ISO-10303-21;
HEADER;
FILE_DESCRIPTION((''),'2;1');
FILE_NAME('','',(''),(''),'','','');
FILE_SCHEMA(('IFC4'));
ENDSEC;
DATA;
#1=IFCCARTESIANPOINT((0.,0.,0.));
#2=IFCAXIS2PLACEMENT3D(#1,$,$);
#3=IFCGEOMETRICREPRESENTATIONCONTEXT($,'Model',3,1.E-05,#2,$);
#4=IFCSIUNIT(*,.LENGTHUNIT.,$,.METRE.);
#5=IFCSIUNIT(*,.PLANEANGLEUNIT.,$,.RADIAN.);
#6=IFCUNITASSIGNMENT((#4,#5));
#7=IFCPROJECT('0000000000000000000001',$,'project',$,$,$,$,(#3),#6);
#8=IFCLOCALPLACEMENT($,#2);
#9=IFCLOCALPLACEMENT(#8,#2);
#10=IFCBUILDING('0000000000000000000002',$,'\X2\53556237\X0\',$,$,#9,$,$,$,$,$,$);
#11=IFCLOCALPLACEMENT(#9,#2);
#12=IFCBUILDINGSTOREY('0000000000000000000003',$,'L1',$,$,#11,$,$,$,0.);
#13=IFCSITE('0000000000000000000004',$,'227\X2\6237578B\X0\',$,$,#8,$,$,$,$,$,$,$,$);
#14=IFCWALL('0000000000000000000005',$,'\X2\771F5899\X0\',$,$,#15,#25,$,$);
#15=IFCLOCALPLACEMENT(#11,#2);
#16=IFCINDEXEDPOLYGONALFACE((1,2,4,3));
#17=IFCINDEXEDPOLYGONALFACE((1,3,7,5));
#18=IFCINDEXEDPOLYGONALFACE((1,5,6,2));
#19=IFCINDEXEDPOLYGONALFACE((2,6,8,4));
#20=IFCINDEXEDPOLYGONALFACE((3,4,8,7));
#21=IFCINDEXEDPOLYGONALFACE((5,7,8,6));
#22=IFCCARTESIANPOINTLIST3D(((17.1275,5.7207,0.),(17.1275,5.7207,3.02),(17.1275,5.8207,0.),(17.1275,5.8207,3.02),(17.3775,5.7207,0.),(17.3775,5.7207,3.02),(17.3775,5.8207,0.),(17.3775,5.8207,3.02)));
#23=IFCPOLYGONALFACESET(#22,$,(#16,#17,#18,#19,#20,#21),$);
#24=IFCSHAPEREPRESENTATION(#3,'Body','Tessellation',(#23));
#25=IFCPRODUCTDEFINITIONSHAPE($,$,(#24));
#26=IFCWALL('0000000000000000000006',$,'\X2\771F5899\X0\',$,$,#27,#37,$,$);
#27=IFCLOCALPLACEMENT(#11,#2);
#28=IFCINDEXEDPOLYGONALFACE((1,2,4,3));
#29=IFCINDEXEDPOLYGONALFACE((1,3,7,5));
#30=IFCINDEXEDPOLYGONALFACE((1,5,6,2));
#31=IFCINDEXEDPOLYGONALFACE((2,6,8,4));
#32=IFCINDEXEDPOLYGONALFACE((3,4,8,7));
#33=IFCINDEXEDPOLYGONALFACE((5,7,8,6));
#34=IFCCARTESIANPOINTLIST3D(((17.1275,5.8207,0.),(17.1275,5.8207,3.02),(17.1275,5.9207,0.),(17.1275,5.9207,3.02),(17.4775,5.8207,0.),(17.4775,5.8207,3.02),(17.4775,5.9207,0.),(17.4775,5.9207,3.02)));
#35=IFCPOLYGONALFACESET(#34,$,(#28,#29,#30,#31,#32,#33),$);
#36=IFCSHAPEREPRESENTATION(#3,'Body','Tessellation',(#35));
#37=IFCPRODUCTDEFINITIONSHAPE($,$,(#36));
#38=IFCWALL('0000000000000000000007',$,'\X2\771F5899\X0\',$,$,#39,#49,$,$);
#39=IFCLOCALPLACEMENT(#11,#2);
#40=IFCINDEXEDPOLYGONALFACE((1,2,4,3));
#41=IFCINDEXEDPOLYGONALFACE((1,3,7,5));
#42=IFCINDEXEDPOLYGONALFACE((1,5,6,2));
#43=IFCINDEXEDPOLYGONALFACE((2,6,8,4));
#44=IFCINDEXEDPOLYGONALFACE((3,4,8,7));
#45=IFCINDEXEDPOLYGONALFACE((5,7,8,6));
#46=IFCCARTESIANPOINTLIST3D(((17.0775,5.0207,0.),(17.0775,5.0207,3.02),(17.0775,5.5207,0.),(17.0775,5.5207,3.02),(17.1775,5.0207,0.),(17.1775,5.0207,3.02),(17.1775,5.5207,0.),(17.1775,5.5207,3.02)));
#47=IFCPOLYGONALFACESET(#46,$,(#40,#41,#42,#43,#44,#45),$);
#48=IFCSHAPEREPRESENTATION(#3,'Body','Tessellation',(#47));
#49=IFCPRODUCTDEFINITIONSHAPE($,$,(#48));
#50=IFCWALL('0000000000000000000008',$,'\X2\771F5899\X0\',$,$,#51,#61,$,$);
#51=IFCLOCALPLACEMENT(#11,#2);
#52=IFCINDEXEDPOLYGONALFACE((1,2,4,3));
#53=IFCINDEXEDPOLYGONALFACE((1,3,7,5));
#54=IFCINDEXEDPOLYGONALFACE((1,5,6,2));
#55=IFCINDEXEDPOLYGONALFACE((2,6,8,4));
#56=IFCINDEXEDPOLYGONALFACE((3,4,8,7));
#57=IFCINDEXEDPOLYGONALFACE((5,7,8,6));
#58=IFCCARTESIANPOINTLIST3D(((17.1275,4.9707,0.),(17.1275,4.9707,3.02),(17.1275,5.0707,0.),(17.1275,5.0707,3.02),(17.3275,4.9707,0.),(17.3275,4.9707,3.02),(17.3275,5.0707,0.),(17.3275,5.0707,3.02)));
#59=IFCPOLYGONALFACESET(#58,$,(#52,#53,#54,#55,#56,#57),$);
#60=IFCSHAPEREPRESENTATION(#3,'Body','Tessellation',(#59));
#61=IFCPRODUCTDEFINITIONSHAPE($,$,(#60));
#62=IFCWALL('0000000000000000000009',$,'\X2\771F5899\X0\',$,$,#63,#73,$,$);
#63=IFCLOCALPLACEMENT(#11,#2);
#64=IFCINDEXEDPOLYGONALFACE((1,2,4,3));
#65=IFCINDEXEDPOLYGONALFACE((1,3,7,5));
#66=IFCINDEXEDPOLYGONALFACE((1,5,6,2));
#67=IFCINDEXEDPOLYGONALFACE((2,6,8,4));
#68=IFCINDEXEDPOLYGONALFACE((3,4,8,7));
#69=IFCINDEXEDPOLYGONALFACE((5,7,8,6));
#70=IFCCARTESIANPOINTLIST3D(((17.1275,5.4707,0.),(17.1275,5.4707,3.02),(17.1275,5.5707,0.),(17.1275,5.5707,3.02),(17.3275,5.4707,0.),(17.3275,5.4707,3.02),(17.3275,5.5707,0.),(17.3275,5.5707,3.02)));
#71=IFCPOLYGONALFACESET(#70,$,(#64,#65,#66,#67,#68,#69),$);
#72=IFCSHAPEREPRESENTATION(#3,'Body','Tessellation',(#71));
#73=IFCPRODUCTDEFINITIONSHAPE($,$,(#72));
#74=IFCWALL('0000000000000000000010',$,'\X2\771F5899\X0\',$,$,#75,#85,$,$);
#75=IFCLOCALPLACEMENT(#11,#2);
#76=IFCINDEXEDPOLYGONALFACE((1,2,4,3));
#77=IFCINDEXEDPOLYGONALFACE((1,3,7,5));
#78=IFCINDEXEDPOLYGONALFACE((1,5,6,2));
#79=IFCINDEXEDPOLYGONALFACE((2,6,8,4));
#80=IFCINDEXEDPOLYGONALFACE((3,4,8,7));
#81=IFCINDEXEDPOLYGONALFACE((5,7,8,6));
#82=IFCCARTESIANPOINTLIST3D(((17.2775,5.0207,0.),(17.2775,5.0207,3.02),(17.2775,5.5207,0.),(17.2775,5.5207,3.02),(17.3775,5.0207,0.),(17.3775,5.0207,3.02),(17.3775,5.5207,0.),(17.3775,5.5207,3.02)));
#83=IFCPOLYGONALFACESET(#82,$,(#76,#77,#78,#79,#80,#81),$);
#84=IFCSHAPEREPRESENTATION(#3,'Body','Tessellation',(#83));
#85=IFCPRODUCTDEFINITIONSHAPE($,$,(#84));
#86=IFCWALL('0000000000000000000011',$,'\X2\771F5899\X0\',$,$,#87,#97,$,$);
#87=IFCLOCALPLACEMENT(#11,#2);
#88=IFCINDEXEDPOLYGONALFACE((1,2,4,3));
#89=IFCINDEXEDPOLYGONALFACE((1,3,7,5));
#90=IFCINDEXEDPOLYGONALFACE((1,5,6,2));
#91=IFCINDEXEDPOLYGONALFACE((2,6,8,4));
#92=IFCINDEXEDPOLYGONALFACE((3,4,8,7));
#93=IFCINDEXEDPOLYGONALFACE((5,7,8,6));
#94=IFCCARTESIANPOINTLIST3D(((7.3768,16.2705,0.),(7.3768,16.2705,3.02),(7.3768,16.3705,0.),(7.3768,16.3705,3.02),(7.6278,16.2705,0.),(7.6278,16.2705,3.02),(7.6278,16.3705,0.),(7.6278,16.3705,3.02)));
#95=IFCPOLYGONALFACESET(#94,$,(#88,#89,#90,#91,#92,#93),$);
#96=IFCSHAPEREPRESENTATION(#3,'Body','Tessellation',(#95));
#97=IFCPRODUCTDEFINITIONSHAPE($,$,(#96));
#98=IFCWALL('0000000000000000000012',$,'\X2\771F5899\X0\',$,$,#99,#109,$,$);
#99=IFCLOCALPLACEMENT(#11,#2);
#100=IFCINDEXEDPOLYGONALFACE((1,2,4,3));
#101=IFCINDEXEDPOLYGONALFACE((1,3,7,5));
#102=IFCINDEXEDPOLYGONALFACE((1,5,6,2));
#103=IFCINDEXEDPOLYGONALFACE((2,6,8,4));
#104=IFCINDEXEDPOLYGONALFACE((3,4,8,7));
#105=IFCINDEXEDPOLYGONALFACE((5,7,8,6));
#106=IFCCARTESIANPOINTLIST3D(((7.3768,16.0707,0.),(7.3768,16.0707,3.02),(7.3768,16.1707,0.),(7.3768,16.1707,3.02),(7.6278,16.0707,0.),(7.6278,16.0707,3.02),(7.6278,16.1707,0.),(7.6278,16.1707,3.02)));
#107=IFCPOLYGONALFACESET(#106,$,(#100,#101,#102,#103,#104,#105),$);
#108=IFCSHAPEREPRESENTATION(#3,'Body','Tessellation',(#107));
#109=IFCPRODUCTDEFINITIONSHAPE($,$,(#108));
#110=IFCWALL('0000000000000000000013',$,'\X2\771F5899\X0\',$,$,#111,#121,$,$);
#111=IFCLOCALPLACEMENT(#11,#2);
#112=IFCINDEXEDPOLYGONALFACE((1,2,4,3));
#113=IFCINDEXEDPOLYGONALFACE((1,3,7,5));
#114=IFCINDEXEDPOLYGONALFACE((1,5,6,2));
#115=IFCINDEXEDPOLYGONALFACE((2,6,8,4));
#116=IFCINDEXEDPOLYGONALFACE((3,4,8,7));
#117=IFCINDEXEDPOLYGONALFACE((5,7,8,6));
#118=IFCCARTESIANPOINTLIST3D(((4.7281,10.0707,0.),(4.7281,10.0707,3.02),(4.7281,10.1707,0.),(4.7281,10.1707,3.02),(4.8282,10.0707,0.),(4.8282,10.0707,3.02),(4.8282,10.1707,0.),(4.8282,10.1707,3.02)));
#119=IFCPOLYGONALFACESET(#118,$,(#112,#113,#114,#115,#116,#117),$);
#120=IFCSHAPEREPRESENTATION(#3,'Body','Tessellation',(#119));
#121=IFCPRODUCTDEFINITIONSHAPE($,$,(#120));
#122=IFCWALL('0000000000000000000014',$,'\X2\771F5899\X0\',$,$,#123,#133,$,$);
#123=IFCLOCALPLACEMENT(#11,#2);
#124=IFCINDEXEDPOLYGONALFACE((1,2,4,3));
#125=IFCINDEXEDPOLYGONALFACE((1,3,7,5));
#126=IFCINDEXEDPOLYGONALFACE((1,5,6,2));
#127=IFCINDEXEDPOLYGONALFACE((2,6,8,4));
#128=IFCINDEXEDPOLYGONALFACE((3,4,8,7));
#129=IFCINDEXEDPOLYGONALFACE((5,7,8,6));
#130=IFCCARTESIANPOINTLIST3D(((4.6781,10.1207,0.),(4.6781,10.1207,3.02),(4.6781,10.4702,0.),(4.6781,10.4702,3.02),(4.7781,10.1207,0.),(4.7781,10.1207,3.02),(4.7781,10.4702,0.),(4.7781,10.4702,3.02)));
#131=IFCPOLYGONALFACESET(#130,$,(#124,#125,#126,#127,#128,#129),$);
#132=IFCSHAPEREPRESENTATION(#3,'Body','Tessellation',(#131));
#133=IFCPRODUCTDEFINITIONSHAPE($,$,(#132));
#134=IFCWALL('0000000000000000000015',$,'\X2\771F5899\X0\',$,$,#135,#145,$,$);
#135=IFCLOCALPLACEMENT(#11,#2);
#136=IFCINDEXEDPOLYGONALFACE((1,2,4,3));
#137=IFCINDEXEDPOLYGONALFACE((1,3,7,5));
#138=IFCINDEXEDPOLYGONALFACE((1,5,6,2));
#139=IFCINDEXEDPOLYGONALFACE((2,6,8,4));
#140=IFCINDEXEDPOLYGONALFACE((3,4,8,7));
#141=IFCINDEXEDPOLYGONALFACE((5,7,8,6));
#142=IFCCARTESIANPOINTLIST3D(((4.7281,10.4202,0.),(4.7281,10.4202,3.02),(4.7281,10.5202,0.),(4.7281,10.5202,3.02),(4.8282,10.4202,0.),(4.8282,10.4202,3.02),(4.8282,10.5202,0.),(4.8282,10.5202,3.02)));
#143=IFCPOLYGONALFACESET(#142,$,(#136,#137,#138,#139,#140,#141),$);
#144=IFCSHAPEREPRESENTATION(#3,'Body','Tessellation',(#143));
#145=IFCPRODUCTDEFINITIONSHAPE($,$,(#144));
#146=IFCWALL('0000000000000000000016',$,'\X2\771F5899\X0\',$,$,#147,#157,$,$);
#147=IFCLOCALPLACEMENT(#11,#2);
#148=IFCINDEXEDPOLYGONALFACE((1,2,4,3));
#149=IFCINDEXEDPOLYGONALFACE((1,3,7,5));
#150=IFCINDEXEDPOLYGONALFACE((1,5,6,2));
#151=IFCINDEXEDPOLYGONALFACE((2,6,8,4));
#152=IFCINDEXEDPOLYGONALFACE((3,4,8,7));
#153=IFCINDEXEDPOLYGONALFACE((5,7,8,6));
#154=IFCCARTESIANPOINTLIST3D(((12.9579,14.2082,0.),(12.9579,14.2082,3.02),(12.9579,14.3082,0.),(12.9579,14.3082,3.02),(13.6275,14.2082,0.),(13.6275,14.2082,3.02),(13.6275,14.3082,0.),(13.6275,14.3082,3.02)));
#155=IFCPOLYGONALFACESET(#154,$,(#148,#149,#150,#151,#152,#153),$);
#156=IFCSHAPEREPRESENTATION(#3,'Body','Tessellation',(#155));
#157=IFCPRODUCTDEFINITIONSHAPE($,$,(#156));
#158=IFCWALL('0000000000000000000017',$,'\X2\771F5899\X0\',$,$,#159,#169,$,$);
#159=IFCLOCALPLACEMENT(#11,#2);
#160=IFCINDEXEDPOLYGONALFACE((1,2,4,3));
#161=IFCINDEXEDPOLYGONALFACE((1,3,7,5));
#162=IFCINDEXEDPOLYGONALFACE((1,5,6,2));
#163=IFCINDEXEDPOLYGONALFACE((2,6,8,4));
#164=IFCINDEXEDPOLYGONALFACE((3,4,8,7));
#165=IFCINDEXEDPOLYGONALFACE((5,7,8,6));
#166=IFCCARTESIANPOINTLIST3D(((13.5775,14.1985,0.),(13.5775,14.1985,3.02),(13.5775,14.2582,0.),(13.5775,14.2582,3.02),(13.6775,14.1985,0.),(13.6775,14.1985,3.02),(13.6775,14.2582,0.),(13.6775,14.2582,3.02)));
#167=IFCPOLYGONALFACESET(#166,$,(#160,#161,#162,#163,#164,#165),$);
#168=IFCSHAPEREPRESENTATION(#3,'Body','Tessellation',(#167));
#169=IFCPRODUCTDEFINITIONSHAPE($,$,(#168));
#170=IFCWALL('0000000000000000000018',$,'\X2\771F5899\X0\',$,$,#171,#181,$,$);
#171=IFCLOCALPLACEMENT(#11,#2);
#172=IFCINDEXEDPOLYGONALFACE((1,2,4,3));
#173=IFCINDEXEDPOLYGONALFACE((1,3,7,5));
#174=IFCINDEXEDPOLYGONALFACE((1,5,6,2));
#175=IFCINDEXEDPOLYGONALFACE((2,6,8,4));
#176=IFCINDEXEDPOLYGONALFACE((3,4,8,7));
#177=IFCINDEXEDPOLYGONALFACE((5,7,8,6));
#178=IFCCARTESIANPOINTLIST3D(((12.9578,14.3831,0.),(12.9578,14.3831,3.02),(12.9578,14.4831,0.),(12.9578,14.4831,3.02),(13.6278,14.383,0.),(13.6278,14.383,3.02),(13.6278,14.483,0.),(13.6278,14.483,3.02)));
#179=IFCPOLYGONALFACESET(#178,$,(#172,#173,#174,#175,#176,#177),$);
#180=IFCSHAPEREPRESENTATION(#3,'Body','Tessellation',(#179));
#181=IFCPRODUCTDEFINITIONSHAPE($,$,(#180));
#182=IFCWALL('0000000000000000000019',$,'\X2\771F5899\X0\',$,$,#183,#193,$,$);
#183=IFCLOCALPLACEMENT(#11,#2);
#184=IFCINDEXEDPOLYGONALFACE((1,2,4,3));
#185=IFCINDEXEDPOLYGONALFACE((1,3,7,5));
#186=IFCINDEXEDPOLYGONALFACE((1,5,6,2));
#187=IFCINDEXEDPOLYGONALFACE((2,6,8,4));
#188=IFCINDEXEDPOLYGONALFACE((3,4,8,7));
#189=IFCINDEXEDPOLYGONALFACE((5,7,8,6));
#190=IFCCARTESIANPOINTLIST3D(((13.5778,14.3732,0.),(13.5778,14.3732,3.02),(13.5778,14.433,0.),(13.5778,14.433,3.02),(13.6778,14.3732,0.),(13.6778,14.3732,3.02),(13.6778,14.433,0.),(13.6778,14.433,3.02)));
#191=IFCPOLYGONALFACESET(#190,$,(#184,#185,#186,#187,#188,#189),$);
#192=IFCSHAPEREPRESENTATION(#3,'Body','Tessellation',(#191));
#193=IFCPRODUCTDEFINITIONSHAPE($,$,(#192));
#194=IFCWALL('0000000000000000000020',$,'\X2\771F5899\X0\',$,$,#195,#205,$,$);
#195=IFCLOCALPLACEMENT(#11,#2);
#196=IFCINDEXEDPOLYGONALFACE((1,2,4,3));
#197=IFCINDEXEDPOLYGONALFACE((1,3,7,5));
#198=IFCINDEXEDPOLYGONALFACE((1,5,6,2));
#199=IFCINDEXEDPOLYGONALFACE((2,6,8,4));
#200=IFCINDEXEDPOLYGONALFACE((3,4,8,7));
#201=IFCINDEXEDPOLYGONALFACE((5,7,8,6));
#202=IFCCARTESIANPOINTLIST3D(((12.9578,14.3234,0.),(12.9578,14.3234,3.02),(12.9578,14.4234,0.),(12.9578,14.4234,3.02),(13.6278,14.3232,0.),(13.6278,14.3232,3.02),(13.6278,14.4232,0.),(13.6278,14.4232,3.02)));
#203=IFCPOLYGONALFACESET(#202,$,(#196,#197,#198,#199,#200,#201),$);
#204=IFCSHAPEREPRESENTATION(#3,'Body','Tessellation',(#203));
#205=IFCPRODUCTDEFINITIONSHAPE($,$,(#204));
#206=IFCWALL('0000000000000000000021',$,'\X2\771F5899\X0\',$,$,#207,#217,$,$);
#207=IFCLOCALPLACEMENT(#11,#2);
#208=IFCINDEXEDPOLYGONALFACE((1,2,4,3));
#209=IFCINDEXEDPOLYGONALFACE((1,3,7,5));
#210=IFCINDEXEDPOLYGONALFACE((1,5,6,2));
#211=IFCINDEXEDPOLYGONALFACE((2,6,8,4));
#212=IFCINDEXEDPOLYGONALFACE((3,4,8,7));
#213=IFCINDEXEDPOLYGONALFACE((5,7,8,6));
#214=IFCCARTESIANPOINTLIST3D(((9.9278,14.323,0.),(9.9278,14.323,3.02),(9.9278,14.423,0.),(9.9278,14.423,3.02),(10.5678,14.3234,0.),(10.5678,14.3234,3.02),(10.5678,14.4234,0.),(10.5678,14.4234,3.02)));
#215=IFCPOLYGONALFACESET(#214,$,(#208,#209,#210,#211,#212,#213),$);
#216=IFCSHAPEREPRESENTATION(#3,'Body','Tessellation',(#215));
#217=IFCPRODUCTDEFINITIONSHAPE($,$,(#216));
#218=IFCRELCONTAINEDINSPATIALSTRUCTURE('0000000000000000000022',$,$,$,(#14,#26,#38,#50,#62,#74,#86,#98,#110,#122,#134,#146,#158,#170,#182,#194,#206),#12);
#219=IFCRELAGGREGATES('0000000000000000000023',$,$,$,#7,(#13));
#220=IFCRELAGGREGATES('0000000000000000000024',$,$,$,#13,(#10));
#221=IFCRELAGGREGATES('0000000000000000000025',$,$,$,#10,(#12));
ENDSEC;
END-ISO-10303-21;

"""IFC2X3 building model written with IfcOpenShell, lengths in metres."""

from ifc_helpers import new_model, si_unit, origin, place, context, project, spatial, polyline, outline, extrude, element, save


model = new_model("IFC2X3")

# Units and contexts
model_context = context("Model", 3, precision=1e-05, world=origin())
ifc_project = project(units=[si_unit("LENGTHUNIT", "METRE"), si_unit("PLANEANGLEUNIT", "RADIAN")], contexts=[model_context])

# Site, building, storey
site_placement = place(None, origin())
site = spatial("IfcSite", under=ifc_project, at=site_placement, Name="227户型")
building_placement = place(site_placement, origin())
building = spatial("IfcBuilding", under=site, at=building_placement, Name="单户")
storey_placement = place(building_placement, origin())
storey = spatial("IfcBuildingStorey", under=building, at=storey_placement, Name="L1", Elevation=0.0)

# Walls
wall_1_placement = place(storey_placement, origin())
element("IfcWall", 1, at=wall_1_placement, inside=storey, Name="真墙", context=model_context, shape_type="SweptSolid", body=[
    extrude(outline(polyline([(17.3775, 5.7207), (17.1275, 5.7207), (17.1275, 5.8207), (17.3775, 5.8207), (17.3775, 5.7207)])), origin(), (0.0, 0.0, 1.0), 3.02),
])
wall_2_placement = place(storey_placement, origin())
element("IfcWall", 2, at=wall_2_placement, inside=storey, Name="真墙", context=model_context, shape_type="SweptSolid", body=[
    extrude(outline(polyline([(17.4775, 5.8207), (17.1275, 5.8207), (17.1275, 5.9207), (17.4775, 5.9207), (17.4775, 5.8207)])), origin(), (0.0, 0.0, 1.0), 3.02),
])
wall_3_placement = place(storey_placement, origin())
element("IfcWall", 3, at=wall_3_placement, inside=storey, Name="真墙", context=model_context, shape_type="SweptSolid", body=[
    extrude(outline(polyline([(17.1775, 5.5207), (17.1775, 5.0207), (17.0775, 5.0207), (17.0775, 5.5207), (17.1775, 5.5207)])), origin(), (0.0, 0.0, 1.0), 3.02),
])
wall_4_placement = place(storey_placement, origin())
element("IfcWall", 4, at=wall_4_placement, inside=storey, Name="真墙", context=model_context, shape_type="SweptSolid", body=[
    extrude(outline(polyline([(17.1275, 5.0707), (17.3275, 5.0707), (17.3275, 4.9707), (17.1275, 4.9707), (17.1275, 5.0707)])), origin(), (0.0, 0.0, 1.0), 3.02),
])
wall_5_placement = place(storey_placement, origin())
element("IfcWall", 5, at=wall_5_placement, inside=storey, Name="真墙", context=model_context, shape_type="SweptSolid", body=[
    extrude(outline(polyline([(17.1275, 5.5707), (17.3275, 5.5707), (17.3275, 5.4707), (17.1275, 5.4707), (17.1275, 5.5707)])), origin(), (0.0, 0.0, 1.0), 3.02),
])
wall_6_placement = place(storey_placement, origin())
element("IfcWall", 6, at=wall_6_placement, inside=storey, Name="真墙", context=model_context, shape_type="SweptSolid", body=[
    extrude(outline(polyline([(17.3775, 5.5207), (17.3775, 5.0207), (17.2775, 5.0207), (17.2775, 5.5207), (17.3775, 5.5207)])), origin(), (0.0, 0.0, 1.0), 3.02),
])
wall_7_placement = place(storey_placement, origin())
element("IfcWall", 7, at=wall_7_placement, inside=storey, Name="真墙", context=model_context, shape_type="SweptSolid", body=[
    extrude(outline(polyline([(7.3768, 16.3705), (7.6278, 16.3705), (7.6278, 16.2705), (7.3768, 16.2705), (7.3768, 16.3705)])), origin(), (0.0, 0.0, 1.0), 3.02),
])

# Walls
wall_8_placement = place(storey_placement, origin())
element("IfcWall", 8, at=wall_8_placement, inside=storey, Name="真墙", context=model_context, shape_type="SweptSolid", body=[
    extrude(outline(polyline([(7.6278, 16.0707), (7.3768, 16.0707), (7.3768, 16.1707), (7.6278, 16.1707), (7.6278, 16.0707)])), origin(), (0.0, 0.0, 1.0), 3.02),
])
wall_9_placement = place(storey_placement, origin())
element("IfcWall", 9, at=wall_9_placement, inside=storey, Name="真墙", context=model_context, shape_type="SweptSolid", body=[
    extrude(outline(polyline([(4.8282, 10.0707), (4.7281, 10.0707), (4.7281, 10.1707), (4.8282, 10.1707), (4.8282, 10.0707)])), origin(), (0.0, 0.0, 1.0), 3.02),
])
wall_10_placement = place(storey_placement, origin())
element("IfcWall", 10, at=wall_10_placement, inside=storey, Name="真墙", context=model_context, shape_type="SweptSolid", body=[
    extrude(outline(polyline([(4.6781, 10.1207), (4.6781, 10.4702), (4.7781, 10.4702), (4.7781, 10.1207), (4.6781, 10.1207)])), origin(), (0.0, 0.0, 1.0), 3.02),
])
wall_11_placement = place(storey_placement, origin())
element("IfcWall", 11, at=wall_11_placement, inside=storey, Name="真墙", context=model_context, shape_type="SweptSolid", body=[
    extrude(outline(polyline([(4.7281, 10.5202), (4.8282, 10.5202), (4.8282, 10.4202), (4.7281, 10.4202), (4.7281, 10.5202)])), origin(), (0.0, 0.0, 1.0), 3.02),
])
wall_12_placement = place(storey_placement, origin())
element("IfcWall", 12, at=wall_12_placement, inside=storey, Name="真墙", context=model_context, shape_type="SweptSolid", body=[
    extrude(outline(polyline([(12.9579, 14.3082), (13.6275, 14.3082), (13.6275, 14.2082), (12.9579, 14.2082), (12.9579, 14.3082)])), origin(), (0.0, 0.0, 1.0), 3.02),
])
wall_13_placement = place(storey_placement, origin())
element("IfcWall", 13, at=wall_13_placement, inside=storey, Name="真墙", context=model_context, shape_type="SweptSolid", body=[
    extrude(outline(polyline([(13.6775, 14.2582), (13.6775, 14.1985), (13.5775, 14.1985), (13.5775, 14.2582), (13.6775, 14.2582)])), origin(), (0.0, 0.0, 1.0), 3.02),
])

# Walls
wall_14_placement = place(storey_placement, origin())
element("IfcWall", 14, at=wall_14_placement, inside=storey, Name="真墙", context=model_context, shape_type="SweptSolid", body=[
    extrude(outline(polyline([(12.9578, 14.4831), (13.6278, 14.483), (13.6278, 14.383), (12.9578, 14.3831), (12.9578, 14.4831)])), origin(), (0.0, 0.0, 1.0), 3.02),
])
wall_15_placement = place(storey_placement, origin())
element("IfcWall", 15, at=wall_15_placement, inside=storey, Name="真墙", context=model_context, shape_type="SweptSolid", body=[
    extrude(outline(polyline([(13.6778, 14.433), (13.6778, 14.3732), (13.5778, 14.3732), (13.5778, 14.433), (13.6778, 14.433)])), origin(), (0.0, 0.0, 1.0), 3.02),
])
wall_16_placement = place(storey_placement, origin())
element("IfcWall", 16, at=wall_16_placement, inside=storey, Name="真墙", context=model_context, shape_type="SweptSolid", body=[
    extrude(outline(polyline([(13.6278, 14.3232), (12.9578, 14.3234), (12.9578, 14.4234), (13.6278, 14.4232), (13.6278, 14.3232)])), origin(), (0.0, 0.0, 1.0), 3.02),
])
wall_17_placement = place(storey_placement, origin())
element("IfcWall", 17, at=wall_17_placement, inside=storey, Name="真墙", context=model_context, shape_type="SweptSolid", body=[
    extrude(outline(polyline([(10.5678, 14.3234), (9.9278, 14.323), (9.9278, 14.423), (10.5678, 14.4234), (10.5678, 14.3234)])), origin(), (0.0, 0.0, 1.0), 3.02),
])

save(model, "model.ifc")
